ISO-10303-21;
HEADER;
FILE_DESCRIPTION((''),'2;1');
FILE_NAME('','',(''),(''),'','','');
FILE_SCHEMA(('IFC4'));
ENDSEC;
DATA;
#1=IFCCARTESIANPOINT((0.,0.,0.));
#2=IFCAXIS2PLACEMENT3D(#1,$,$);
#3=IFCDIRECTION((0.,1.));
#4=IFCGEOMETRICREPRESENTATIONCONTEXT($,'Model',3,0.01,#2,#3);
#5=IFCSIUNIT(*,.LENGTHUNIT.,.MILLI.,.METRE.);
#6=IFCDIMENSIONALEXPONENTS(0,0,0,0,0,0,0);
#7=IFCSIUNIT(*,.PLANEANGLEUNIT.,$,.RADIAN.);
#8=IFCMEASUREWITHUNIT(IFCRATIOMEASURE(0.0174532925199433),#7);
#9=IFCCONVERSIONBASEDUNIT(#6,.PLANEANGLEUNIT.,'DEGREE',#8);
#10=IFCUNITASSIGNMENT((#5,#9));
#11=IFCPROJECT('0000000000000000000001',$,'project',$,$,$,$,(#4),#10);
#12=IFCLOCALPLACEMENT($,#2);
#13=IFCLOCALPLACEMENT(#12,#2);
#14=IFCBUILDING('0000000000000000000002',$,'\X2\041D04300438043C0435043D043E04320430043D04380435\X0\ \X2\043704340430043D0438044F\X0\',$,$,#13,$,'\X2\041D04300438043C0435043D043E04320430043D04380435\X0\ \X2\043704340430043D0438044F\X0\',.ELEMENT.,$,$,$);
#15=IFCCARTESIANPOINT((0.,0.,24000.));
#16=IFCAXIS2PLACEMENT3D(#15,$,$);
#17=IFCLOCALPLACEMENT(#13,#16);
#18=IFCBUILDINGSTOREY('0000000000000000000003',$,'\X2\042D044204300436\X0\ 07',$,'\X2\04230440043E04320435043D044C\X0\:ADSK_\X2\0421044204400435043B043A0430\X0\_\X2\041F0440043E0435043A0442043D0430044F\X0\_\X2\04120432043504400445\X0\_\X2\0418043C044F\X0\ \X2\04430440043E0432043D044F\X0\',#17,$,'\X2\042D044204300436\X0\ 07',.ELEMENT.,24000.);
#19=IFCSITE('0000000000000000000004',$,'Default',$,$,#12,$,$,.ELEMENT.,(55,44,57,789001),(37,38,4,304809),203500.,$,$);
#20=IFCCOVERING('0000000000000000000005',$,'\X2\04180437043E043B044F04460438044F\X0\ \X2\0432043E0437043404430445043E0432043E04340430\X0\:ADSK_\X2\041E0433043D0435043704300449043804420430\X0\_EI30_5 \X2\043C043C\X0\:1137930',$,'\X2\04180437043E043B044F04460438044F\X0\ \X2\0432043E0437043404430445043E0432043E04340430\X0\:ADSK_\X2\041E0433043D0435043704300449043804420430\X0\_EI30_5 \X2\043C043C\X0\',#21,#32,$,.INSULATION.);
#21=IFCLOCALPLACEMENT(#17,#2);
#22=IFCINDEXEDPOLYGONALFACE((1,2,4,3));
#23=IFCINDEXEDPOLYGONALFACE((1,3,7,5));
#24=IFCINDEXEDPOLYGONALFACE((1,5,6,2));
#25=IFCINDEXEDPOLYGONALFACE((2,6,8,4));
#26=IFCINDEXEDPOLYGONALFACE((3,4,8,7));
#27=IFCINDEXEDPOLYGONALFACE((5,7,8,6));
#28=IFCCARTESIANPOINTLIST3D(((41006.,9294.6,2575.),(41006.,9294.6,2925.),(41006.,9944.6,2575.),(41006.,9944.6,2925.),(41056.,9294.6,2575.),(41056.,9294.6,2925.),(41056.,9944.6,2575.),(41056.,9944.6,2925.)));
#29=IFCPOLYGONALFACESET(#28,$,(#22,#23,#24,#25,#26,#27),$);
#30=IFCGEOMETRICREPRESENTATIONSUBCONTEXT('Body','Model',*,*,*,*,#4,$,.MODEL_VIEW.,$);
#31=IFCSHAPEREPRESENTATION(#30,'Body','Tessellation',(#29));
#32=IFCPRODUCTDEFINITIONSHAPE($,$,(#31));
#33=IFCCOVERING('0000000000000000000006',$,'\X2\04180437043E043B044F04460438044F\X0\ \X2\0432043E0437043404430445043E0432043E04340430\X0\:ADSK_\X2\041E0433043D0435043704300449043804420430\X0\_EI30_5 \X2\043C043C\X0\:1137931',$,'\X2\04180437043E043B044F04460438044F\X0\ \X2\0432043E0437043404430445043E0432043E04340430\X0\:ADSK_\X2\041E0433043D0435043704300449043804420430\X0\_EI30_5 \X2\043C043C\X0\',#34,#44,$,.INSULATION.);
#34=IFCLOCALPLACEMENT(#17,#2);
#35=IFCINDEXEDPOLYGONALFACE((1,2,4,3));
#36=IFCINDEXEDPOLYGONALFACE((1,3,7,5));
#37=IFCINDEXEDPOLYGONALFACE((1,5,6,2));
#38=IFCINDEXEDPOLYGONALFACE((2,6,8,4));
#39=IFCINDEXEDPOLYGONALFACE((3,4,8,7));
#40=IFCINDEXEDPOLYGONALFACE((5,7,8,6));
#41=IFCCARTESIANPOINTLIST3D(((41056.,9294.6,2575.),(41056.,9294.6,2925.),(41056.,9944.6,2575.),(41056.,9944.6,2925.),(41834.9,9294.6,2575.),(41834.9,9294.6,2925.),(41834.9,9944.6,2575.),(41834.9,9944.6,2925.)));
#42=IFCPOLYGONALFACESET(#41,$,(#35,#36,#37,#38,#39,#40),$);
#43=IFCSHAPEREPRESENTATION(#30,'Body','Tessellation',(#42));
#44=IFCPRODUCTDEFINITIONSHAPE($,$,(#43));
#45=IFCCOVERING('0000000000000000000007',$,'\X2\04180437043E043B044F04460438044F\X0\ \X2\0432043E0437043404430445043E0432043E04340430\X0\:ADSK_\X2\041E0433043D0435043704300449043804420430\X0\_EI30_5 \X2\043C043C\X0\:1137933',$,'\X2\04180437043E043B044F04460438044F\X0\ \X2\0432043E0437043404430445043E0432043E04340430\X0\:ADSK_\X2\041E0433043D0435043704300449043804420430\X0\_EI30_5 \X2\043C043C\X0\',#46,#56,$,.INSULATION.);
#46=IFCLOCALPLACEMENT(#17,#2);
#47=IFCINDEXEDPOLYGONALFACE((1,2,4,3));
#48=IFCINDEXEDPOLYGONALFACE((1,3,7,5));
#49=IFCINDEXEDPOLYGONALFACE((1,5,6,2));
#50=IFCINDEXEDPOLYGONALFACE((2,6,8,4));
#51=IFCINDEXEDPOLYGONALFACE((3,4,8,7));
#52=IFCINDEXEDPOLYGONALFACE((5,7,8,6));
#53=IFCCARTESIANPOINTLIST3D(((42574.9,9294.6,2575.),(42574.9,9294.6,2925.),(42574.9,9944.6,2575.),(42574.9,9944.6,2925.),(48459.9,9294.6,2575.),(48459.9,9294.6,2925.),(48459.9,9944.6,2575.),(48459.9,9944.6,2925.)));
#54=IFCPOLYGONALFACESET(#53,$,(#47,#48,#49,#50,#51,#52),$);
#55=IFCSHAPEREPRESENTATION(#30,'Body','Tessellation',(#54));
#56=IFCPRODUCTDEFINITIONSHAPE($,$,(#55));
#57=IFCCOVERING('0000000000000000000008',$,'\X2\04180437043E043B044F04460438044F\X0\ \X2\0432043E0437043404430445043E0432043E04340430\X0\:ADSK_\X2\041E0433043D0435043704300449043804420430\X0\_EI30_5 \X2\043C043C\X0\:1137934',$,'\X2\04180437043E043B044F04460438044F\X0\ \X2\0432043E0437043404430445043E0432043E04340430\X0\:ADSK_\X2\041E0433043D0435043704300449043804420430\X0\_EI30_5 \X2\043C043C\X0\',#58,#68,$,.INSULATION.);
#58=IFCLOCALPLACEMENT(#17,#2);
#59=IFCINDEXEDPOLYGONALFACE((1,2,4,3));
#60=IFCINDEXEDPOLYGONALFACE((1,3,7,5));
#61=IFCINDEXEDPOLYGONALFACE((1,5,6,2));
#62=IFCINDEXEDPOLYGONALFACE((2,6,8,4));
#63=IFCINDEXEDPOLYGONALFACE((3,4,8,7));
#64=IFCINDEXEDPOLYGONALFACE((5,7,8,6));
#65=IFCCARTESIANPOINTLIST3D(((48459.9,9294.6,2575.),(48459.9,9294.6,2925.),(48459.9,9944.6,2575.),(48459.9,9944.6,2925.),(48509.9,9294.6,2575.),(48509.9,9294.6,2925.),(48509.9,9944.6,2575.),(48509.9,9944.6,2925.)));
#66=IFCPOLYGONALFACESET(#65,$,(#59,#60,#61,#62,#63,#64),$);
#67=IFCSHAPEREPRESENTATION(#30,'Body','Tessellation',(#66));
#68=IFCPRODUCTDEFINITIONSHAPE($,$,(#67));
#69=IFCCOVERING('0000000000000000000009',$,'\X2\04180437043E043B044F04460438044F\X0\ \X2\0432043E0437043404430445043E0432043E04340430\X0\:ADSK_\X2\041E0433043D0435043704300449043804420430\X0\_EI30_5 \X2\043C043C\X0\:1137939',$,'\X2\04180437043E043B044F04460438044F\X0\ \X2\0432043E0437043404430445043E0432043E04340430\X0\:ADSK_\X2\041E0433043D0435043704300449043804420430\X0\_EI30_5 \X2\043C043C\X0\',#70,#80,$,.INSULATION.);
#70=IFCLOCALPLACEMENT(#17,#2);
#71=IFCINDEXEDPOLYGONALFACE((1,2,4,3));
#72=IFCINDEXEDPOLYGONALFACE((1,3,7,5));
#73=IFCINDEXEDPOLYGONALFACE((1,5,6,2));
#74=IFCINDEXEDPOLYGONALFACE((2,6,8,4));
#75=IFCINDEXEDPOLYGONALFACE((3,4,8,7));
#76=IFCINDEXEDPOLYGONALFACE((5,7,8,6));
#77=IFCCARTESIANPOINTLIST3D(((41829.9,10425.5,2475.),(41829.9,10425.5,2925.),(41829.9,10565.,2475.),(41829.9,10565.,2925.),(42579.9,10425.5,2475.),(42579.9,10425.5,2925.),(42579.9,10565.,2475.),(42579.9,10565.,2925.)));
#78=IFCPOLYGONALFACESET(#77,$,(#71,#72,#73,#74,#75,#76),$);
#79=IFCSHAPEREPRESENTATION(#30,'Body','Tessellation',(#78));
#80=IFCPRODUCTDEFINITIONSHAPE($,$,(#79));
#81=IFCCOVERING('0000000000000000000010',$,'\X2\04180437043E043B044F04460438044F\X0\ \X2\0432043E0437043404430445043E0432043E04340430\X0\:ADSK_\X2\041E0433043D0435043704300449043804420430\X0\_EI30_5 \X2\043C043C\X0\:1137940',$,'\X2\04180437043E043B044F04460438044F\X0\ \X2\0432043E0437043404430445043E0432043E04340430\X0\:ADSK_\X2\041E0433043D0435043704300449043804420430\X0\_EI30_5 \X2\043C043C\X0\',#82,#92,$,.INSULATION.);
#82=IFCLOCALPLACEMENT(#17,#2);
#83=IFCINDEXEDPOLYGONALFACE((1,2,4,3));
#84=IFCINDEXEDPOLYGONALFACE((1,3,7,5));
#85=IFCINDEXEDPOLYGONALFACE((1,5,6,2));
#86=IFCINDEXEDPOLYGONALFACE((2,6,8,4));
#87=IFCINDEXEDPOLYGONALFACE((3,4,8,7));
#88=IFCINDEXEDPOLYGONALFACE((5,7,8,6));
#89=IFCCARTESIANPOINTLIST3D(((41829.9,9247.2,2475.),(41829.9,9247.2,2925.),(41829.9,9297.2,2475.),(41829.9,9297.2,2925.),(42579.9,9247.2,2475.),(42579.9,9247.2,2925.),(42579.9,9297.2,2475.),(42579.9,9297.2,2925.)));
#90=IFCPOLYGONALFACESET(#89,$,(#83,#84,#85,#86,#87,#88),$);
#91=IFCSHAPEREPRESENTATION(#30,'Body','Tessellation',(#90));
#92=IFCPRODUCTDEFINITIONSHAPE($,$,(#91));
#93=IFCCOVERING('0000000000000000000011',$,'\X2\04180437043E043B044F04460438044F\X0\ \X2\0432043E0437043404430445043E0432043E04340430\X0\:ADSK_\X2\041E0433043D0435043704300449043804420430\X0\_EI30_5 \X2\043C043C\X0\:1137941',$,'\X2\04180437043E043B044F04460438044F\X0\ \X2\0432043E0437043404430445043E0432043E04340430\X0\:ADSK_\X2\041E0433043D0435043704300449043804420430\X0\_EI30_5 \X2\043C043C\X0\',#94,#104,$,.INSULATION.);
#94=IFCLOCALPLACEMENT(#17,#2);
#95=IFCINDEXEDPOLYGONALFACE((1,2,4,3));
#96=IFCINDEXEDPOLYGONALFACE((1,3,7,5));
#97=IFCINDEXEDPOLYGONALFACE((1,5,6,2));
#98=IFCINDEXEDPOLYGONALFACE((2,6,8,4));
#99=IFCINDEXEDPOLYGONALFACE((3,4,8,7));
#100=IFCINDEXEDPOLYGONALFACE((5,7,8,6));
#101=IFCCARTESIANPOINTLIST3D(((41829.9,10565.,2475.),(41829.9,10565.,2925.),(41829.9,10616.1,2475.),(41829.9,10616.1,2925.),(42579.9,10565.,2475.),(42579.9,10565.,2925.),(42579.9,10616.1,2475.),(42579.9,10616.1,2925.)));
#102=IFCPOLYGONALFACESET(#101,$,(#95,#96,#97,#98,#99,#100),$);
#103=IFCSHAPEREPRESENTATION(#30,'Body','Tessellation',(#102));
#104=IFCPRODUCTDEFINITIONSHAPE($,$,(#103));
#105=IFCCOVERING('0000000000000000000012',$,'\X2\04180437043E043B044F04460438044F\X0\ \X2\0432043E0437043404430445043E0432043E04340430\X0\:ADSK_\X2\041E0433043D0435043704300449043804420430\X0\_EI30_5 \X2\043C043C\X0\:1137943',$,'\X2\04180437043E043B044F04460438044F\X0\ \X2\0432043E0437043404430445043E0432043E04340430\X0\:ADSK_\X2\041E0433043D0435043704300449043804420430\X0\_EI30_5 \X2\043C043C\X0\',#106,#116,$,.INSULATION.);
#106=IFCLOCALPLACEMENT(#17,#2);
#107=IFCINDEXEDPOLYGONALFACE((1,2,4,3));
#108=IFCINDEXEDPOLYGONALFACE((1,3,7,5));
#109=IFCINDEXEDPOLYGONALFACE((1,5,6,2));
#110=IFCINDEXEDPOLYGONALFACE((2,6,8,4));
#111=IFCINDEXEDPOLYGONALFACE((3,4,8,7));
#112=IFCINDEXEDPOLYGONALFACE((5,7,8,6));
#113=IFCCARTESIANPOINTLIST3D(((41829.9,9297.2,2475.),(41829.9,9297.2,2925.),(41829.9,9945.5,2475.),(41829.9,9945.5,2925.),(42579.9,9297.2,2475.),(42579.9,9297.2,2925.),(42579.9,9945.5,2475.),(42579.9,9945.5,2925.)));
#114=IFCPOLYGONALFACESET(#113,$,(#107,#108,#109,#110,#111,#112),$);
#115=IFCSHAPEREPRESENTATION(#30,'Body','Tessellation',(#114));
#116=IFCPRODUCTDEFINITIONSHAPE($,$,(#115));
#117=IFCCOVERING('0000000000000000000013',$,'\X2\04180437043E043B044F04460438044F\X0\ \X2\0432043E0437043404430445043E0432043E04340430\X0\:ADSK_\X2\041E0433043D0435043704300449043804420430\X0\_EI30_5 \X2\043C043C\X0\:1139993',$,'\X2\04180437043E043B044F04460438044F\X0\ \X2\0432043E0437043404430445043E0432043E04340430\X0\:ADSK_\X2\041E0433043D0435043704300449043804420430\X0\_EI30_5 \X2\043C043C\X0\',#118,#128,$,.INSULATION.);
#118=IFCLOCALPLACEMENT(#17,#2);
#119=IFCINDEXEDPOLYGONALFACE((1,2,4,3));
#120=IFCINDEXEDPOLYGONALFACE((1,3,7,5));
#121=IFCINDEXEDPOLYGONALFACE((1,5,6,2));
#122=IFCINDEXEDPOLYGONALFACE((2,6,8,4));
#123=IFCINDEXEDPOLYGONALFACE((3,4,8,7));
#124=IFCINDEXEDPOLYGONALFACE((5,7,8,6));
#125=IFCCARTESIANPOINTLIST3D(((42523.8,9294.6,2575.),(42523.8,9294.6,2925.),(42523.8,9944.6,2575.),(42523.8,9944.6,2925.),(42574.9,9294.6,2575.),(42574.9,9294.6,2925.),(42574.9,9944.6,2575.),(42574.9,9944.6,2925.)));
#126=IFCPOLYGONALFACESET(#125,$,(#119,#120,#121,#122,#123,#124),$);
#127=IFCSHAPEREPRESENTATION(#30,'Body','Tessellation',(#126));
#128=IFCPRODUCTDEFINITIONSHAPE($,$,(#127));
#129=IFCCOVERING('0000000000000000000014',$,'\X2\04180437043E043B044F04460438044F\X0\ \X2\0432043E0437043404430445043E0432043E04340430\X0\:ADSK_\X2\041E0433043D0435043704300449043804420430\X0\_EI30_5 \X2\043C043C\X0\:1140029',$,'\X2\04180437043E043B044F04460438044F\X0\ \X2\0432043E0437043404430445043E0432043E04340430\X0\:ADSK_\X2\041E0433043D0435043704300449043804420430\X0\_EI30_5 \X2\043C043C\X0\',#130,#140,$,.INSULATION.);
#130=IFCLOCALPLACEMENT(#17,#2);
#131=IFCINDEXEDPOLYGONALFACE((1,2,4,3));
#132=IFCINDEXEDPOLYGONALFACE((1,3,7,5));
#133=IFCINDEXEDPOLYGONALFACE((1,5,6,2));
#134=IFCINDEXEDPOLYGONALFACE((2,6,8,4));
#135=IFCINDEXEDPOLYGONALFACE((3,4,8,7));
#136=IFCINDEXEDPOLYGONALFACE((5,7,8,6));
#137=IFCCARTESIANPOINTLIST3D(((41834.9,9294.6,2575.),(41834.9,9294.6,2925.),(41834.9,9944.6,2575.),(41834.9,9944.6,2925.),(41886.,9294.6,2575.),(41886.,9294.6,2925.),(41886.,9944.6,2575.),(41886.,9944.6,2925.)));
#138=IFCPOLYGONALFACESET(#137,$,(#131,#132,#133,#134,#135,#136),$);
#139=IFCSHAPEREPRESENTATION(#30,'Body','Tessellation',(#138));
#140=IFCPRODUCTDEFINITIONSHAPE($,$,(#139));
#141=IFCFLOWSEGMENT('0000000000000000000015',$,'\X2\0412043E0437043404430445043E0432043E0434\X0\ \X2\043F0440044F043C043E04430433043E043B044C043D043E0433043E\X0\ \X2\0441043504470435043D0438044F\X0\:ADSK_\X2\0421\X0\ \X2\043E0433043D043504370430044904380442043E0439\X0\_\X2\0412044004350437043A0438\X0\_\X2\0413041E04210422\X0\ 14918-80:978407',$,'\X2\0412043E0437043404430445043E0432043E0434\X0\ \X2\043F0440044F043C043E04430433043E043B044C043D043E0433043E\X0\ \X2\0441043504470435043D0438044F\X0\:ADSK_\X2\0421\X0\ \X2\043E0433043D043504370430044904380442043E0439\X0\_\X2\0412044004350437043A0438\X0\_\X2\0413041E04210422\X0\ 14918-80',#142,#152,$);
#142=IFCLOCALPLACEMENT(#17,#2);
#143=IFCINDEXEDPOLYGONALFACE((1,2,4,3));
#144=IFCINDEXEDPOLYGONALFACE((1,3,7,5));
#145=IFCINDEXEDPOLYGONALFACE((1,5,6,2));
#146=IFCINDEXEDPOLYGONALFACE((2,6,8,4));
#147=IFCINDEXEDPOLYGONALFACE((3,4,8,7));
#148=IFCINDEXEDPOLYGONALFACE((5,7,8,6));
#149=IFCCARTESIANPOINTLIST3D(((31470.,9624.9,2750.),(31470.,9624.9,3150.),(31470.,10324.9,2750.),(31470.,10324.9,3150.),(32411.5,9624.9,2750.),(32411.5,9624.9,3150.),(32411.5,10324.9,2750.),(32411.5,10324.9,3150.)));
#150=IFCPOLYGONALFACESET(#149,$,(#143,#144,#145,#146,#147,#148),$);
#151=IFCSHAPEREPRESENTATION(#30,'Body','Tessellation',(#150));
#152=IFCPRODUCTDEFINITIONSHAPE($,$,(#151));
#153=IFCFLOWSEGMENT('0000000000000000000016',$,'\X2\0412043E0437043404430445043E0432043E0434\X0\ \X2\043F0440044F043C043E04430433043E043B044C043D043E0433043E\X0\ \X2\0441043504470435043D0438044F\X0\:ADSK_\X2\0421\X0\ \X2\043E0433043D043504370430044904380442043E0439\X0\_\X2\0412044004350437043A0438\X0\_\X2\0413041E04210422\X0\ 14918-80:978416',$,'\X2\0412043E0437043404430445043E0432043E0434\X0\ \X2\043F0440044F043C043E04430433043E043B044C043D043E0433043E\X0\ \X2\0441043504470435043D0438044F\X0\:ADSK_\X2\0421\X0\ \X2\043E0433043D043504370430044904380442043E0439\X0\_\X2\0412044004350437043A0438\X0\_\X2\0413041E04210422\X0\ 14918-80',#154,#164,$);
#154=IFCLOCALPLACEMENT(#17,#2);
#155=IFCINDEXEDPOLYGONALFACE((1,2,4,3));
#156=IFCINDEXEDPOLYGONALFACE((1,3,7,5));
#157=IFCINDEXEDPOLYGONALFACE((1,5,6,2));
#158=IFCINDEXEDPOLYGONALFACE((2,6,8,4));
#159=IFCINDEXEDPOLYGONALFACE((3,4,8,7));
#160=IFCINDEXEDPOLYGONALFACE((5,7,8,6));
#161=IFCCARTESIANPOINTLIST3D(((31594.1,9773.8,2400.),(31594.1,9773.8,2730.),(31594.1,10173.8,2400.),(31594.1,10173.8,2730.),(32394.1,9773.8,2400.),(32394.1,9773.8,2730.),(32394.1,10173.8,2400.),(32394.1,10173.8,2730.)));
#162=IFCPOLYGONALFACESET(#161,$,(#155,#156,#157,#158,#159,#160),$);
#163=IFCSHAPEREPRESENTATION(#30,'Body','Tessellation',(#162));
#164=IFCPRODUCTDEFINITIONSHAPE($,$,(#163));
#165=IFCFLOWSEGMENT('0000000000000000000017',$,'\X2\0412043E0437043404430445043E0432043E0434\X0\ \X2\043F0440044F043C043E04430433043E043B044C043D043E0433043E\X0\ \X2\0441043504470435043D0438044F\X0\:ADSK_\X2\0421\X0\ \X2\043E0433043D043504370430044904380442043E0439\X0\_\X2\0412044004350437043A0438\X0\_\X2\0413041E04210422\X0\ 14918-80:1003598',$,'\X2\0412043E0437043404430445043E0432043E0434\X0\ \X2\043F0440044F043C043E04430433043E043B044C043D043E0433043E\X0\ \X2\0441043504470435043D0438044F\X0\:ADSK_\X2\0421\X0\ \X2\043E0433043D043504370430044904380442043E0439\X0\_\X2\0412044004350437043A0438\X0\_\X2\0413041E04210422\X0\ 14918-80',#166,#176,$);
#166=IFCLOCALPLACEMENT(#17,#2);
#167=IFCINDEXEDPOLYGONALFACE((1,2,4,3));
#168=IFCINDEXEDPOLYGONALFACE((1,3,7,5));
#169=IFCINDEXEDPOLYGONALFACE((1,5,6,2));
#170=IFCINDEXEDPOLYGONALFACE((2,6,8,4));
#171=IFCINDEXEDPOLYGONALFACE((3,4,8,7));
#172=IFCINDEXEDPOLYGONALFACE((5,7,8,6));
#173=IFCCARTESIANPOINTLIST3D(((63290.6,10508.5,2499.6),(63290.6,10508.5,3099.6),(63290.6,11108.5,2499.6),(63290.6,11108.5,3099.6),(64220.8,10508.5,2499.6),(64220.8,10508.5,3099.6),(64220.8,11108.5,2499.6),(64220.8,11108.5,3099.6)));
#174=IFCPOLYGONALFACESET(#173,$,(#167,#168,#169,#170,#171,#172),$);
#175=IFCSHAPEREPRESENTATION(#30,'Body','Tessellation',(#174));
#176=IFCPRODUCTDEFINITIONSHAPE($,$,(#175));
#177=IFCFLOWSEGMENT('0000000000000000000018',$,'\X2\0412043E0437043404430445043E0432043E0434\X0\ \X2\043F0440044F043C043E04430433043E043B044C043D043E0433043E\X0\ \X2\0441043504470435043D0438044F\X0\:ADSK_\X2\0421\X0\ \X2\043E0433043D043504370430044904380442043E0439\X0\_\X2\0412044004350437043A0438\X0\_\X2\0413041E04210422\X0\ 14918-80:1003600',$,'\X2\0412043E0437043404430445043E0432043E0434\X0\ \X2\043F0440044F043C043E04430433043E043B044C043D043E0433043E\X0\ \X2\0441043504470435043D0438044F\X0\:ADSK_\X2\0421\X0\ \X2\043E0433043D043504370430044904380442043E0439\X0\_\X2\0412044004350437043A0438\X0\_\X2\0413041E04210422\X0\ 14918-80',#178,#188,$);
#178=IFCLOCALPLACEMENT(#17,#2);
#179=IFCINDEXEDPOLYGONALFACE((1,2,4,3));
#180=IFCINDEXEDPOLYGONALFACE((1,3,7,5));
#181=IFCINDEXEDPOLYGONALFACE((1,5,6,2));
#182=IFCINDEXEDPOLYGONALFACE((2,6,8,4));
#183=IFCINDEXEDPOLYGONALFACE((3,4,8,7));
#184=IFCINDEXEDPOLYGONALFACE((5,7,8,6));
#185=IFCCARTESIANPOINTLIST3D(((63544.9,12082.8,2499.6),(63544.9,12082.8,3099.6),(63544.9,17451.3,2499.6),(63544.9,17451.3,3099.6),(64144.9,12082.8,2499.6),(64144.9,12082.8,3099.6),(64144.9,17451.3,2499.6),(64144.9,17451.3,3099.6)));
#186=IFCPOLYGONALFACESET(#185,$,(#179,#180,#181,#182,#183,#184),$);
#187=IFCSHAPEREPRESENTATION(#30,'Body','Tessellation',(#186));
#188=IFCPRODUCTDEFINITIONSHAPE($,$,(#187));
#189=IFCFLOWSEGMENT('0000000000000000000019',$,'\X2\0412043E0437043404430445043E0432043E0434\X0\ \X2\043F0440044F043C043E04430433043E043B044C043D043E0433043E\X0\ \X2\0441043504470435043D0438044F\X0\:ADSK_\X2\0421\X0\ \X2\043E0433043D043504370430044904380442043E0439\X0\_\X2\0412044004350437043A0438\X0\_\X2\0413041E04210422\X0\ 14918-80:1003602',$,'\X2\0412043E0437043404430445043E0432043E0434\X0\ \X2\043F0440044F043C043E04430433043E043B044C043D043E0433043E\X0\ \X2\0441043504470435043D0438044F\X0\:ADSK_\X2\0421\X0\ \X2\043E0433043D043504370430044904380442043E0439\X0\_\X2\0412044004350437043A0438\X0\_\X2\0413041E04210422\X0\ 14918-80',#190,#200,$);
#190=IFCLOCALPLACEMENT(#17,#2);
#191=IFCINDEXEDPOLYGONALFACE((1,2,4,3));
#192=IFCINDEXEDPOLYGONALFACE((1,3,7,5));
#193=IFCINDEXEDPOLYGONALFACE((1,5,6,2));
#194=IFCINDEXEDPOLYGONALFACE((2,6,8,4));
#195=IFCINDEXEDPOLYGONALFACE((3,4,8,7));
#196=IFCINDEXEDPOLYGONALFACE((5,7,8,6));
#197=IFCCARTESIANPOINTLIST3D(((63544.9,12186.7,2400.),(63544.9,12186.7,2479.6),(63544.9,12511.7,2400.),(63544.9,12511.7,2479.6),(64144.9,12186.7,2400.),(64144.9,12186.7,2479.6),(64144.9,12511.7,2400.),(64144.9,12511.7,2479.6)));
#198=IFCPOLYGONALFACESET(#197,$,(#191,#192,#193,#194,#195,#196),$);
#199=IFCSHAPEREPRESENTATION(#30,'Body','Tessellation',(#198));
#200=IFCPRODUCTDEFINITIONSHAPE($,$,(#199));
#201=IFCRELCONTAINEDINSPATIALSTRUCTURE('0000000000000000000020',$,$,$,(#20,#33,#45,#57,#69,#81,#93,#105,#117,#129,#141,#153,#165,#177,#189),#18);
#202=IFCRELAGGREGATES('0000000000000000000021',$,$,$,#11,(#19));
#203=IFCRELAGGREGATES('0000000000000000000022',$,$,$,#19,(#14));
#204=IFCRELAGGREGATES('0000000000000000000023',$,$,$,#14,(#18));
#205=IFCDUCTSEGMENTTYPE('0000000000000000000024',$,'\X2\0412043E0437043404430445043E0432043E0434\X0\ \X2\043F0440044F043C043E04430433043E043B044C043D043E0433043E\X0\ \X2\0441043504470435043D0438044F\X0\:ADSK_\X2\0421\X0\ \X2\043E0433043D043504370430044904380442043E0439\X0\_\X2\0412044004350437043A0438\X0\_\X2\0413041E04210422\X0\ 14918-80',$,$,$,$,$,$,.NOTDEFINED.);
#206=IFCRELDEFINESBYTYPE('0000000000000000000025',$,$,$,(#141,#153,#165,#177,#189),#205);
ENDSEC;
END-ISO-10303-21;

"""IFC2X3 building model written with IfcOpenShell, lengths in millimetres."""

from ifc_helpers import new_model, entity, si_unit, converted_unit, direction, frame, frame_2d, origin, origin_2d_with_axis, place, context, subcontext, project, spatial, rectangle, extrude, type_object, element, save


model = new_model("IFC2X3")

# Units and contexts
model_context = context("Model", 3, precision=0.01, world=origin(), true_north=direction((0.0, 1.0)))
body_context = subcontext(model_context, "Body", "Model", "MODEL_VIEW")
ifc_project = project(units=[si_unit("LENGTHUNIT", "METRE", prefix="MILLI"), converted_unit("PLANEANGLEUNIT", "DEGREE", entity("IfcRatioMeasure", 0.0174532925199433), si_unit("PLANEANGLEUNIT", "RADIAN"), dimensions=[0, 0, 0, 0, 0, 0, 0])], contexts=[model_context])

# Site, building, storey
site_placement = place(None, frame((0.0, 0.0, 0.0)))
site = spatial("IfcSite", under=ifc_project, at=site_placement, Name="Default", CompositionType="ELEMENT", RefLatitude=(55, 44, 57, 789001), RefLongitude=(37, 38, 4, 304809), RefElevation=203500.0)
building_placement = place(site_placement, origin())
building = spatial("IfcBuilding", under=site, at=building_placement, Name="Наименование здания", LongName="Наименование здания", CompositionType="ELEMENT")
storey_placement = place(building_placement, frame((0.0, 0.0, 24000.0)))
storey = spatial("IfcBuildingStorey", under=building, at=storey_placement, Name="Этаж 07", ObjectType="Уровень:ADSK_Стрелка_Проектная_Вверх_Имя уровня", LongName="Этаж 07", CompositionType="ELEMENT", Elevation=24000.0)

# Coverings
covering_1_placement = place(storey_placement, frame((41006.0, 9294.6, 2575.0)))
element("IfcCovering", 1, at=covering_1_placement, inside=storey, Name="Изоляция воздуховода:ADSK_Огнезащита_EI30_5 мм:1137930", ObjectType="Изоляция воздуховода:ADSK_Огнезащита_EI30_5 мм", PredefinedType="INSULATION", context=body_context, shape_type="SweptSolid", body=[
    extrude(rectangle(XDim=50.0, YDim=650.0, at=frame_2d((0.0, 0.0), x_axis=(1.0, 0.0))), frame((25.0, 325.0, 0.0)), (0.0, 0.0, 1.0), 350.0),
])
covering_2_placement = place(storey_placement, frame((41056.0, 9294.6, 2575.0)))
element("IfcCovering", 2, at=covering_2_placement, inside=storey, Name="Изоляция воздуховода:ADSK_Огнезащита_EI30_5 мм:1137931", ObjectType="Изоляция воздуховода:ADSK_Огнезащита_EI30_5 мм", PredefinedType="INSULATION", context=body_context, shape_type="SweptSolid", body=[
    extrude(rectangle(XDim=778.9, YDim=650.0, at=frame_2d((0.0, 0.0), x_axis=(1.0, 0.0))), frame((389.4, 325.0, 0.0)), (0.0, 0.0, 1.0), 350.0),
])
covering_3_placement = place(storey_placement, frame((42574.9, 9294.6, 2575.0)))
element("IfcCovering", 3, at=covering_3_placement, inside=storey, Name="Изоляция воздуховода:ADSK_Огнезащита_EI30_5 мм:1137933", ObjectType="Изоляция воздуховода:ADSK_Огнезащита_EI30_5 мм", PredefinedType="INSULATION", context=body_context, shape_type="SweptSolid", body=[
    extrude(rectangle(XDim=5885.0, YDim=650.0, at=frame_2d((0.0, 0.0), x_axis=(1.0, 0.0))), frame((2942.5, 325.0, 0.0), z_axis=(0.0, 0.0, 1.0), x_axis=(-1.0, 0.0, 0.0)), (0.0, 0.0, 1.0), 350.0),
])
covering_4_placement = place(storey_placement, frame((48459.9, 9294.6, 2575.0)))
element("IfcCovering", 4, at=covering_4_placement, inside=storey, Name="Изоляция воздуховода:ADSK_Огнезащита_EI30_5 мм:1137934", ObjectType="Изоляция воздуховода:ADSK_Огнезащита_EI30_5 мм", PredefinedType="INSULATION", context=body_context, shape_type="SweptSolid", body=[
    extrude(rectangle(XDim=50.0, YDim=650.0, at=frame_2d((0.0, 0.0), x_axis=(1.0, 0.0))), frame((25.0, 325.0, 0.0), z_axis=(0.0, 0.0, 1.0), x_axis=(-1.0, 0.0, 0.0)), (0.0, 0.0, 1.0), 350.0),
])
covering_5_placement = place(storey_placement, frame((41829.9, 10425.5, 2475.0)))
element("IfcCovering", 5, at=covering_5_placement, inside=storey, Name="Изоляция воздуховода:ADSK_Огнезащита_EI30_5 мм:1137939", ObjectType="Изоляция воздуховода:ADSK_Огнезащита_EI30_5 мм", PredefinedType="INSULATION", context=body_context, shape_type="SweptSolid", body=[
    extrude(rectangle(XDim=139.5, YDim=750.0, at=origin_2d_with_axis()), frame((375.0, 69.7, 0.0), z_axis=(0.0, 0.0, 1.0), x_axis=(0.0, 1.0, 0.0)), (0.0, 0.0, 1.0), 450.0),
])
covering_6_placement = place(storey_placement, frame((41829.9, 9247.2, 2475.0)))
element("IfcCovering", 6, at=covering_6_placement, inside=storey, Name="Изоляция воздуховода:ADSK_Огнезащита_EI30_5 мм:1137940", ObjectType="Изоляция воздуховода:ADSK_Огнезащита_EI30_5 мм", PredefinedType="INSULATION", context=body_context, shape_type="SweptSolid", body=[
    extrude(rectangle(XDim=50.0, YDim=750.0, at=origin_2d_with_axis()), frame((375.0, 25.0, 0.0), z_axis=(0.0, 0.0, 1.0), x_axis=(0.0, 1.0, 0.0)), (0.0, 0.0, 1.0), 450.0),
])
covering_7_placement = place(storey_placement, frame((41829.9, 10565.0, 2475.0)))
element("IfcCovering", 7, at=covering_7_placement, inside=storey, Name="Изоляция воздуховода:ADSK_Огнезащита_EI30_5 мм:1137941", ObjectType="Изоляция воздуховода:ADSK_Огнезащита_EI30_5 мм", PredefinedType="INSULATION", context=body_context, shape_type="SweptSolid", body=[
    extrude(rectangle(XDim=750.0, YDim=51.1, at=origin_2d_with_axis()), frame((375.0, 25.5, 0.0)), (0.0, 0.0, 1.0), 450.0),
])
covering_8_placement = place(storey_placement, frame((41829.9, 9297.2, 2475.0)))
element("IfcCovering", 8, at=covering_8_placement, inside=storey, Name="Изоляция воздуховода:ADSK_Огнезащита_EI30_5 мм:1137943", ObjectType="Изоляция воздуховода:ADSK_Огнезащита_EI30_5 мм", PredefinedType="INSULATION", context=body_context, shape_type="SweptSolid", body=[
    extrude(rectangle(XDim=648.3, YDim=750.0, at=frame_2d((0.0, 0.0), x_axis=(1.0, 0.0))), frame((375.0, 324.1, 0.0), z_axis=(0.0, 0.0, 1.0), x_axis=(0.0, 1.0, 0.0)), (0.0, 0.0, 1.0), 450.0),
])
covering_9_placement = place(storey_placement, frame((42523.8, 9294.6, 2575.0)))
element("IfcCovering", 9, at=covering_9_placement, inside=storey, Name="Изоляция воздуховода:ADSK_Огнезащита_EI30_5 мм:1139993", ObjectType="Изоляция воздуховода:ADSK_Огнезащита_EI30_5 мм", PredefinedType="INSULATION", context=body_context, shape_type="SweptSolid", body=[
    extrude(rectangle(XDim=51.1, YDim=650.0, at=frame_2d((0.0, 0.0), x_axis=(1.0, 0.0))), frame((25.5, 325.0, 0.0), z_axis=(0.0, 0.0, 1.0), x_axis=(-1.0, 0.0, 0.0)), (0.0, 0.0, 1.0), 350.0),
])
covering_10_placement = place(storey_placement, frame((41834.9, 9294.6, 2575.0)))
element("IfcCovering", 10, at=covering_10_placement, inside=storey, Name="Изоляция воздуховода:ADSK_Огнезащита_EI30_5 мм:1140029", ObjectType="Изоляция воздуховода:ADSK_Огнезащита_EI30_5 мм", PredefinedType="INSULATION", context=body_context, shape_type="SweptSolid", body=[
    extrude(rectangle(XDim=650.0, YDim=51.1, at=frame_2d((0.0, 0.0), x_axis=(1.0, 0.0))), frame((25.5, 325.0, 0.0), z_axis=(0.0, 0.0, 1.0), x_axis=(0.0, -1.0, 0.0)), (0.0, 0.0, 1.0), 350.0),
])

# Flow segments
duct_segment_type_1 = type_object("IfcDuctSegmentType", Name="Воздуховод прямоугольного сечения:ADSK_С огнезащитой_Врезки_ГОСТ 14918-80", PredefinedType="NOTDEFINED")
flow_segment_1_placement = place(storey_placement, frame((31470.0, 9624.9, 2750.0)))
element("IfcFlowSegment", 11, at=flow_segment_1_placement, inside=storey, type_object=duct_segment_type_1, Name="Воздуховод прямоугольного сечения:ADSK_С огнезащитой_Врезки_ГОСТ 14918-80:978407", ObjectType="Воздуховод прямоугольного сечения:ADSK_С огнезащитой_Врезки_ГОСТ 14918-80", context=body_context, shape_type="SweptSolid", body=[
    extrude(rectangle(XDim=941.5, YDim=700.0, at=frame_2d((0.0, 0.0), x_axis=(1.0, 0.0))), frame((470.7, 350.0, 0.0), z_axis=(0.0, 0.0, 1.0), x_axis=(-1.0, 0.0, 0.0)), (0.0, 0.0, 1.0), 400.0),
])
flow_segment_2_placement = place(storey_placement, frame((31594.1, 9773.8, 2400.0)))
element("IfcFlowSegment", 12, at=flow_segment_2_placement, inside=storey, type_object=duct_segment_type_1, Name="Воздуховод прямоугольного сечения:ADSK_С огнезащитой_Врезки_ГОСТ 14918-80:978416", ObjectType="Воздуховод прямоугольного сечения:ADSK_С огнезащитой_Врезки_ГОСТ 14918-80", context=body_context, shape_type="SweptSolid", body=[
    extrude(rectangle(XDim=800.0, YDim=400.0, at=origin_2d_with_axis()), frame((400.0, 200.0, 0.0)), (0.0, 0.0, 1.0), 330.0),
])
flow_segment_3_placement = place(storey_placement, frame((63290.6, 10508.5, 2499.6)))
element("IfcFlowSegment", 13, at=flow_segment_3_placement, inside=storey, type_object=duct_segment_type_1, Name="Воздуховод прямоугольного сечения:ADSK_С огнезащитой_Врезки_ГОСТ 14918-80:1003598", ObjectType="Воздуховод прямоугольного сечения:ADSK_С огнезащитой_Врезки_ГОСТ 14918-80", context=body_context, shape_type="SweptSolid", body=[
    extrude(rectangle(XDim=930.2, YDim=600.0, at=frame_2d((0.0, 0.0), x_axis=(1.0, 0.0))), frame((465.1, 300.0, 0.0)), (0.0, 0.0, 1.0), 600.0),
])
flow_segment_4_placement = place(storey_placement, frame((63544.9, 12082.8, 2499.6)))
element("IfcFlowSegment", 14, at=flow_segment_4_placement, inside=storey, type_object=duct_segment_type_1, Name="Воздуховод прямоугольного сечения:ADSK_С огнезащитой_Врезки_ГОСТ 14918-80:1003600", ObjectType="Воздуховод прямоугольного сечения:ADSK_С огнезащитой_Врезки_ГОСТ 14918-80", context=body_context, shape_type="SweptSolid", body=[
    extrude(rectangle(XDim=5368.5, YDim=600.0, at=origin_2d_with_axis()), frame((300.0, 2684.3, 0.0), z_axis=(0.0, 0.0, 1.0), x_axis=(0.0, 1.0, 0.0)), (0.0, 0.0, 1.0), 600.0),
])
flow_segment_5_placement = place(storey_placement, frame((63544.9, 12186.7, 2400.0)))
element("IfcFlowSegment", 15, at=flow_segment_5_placement, inside=storey, type_object=duct_segment_type_1, Name="Воздуховод прямоугольного сечения:ADSK_С огнезащитой_Врезки_ГОСТ 14918-80:1003602", ObjectType="Воздуховод прямоугольного сечения:ADSK_С огнезащитой_Врезки_ГОСТ 14918-80", context=body_context, shape_type="SweptSolid", body=[
    extrude(rectangle(XDim=600.0, YDim=325.0, at=origin_2d_with_axis()), frame((300.0, 162.5, 0.0), z_axis=(0.0, 0.0, 1.0), x_axis=(-1.0, 0.0, 0.0)), (0.0, 0.0, 1.0), 79.6),
])

save(model, "model.ifc")
